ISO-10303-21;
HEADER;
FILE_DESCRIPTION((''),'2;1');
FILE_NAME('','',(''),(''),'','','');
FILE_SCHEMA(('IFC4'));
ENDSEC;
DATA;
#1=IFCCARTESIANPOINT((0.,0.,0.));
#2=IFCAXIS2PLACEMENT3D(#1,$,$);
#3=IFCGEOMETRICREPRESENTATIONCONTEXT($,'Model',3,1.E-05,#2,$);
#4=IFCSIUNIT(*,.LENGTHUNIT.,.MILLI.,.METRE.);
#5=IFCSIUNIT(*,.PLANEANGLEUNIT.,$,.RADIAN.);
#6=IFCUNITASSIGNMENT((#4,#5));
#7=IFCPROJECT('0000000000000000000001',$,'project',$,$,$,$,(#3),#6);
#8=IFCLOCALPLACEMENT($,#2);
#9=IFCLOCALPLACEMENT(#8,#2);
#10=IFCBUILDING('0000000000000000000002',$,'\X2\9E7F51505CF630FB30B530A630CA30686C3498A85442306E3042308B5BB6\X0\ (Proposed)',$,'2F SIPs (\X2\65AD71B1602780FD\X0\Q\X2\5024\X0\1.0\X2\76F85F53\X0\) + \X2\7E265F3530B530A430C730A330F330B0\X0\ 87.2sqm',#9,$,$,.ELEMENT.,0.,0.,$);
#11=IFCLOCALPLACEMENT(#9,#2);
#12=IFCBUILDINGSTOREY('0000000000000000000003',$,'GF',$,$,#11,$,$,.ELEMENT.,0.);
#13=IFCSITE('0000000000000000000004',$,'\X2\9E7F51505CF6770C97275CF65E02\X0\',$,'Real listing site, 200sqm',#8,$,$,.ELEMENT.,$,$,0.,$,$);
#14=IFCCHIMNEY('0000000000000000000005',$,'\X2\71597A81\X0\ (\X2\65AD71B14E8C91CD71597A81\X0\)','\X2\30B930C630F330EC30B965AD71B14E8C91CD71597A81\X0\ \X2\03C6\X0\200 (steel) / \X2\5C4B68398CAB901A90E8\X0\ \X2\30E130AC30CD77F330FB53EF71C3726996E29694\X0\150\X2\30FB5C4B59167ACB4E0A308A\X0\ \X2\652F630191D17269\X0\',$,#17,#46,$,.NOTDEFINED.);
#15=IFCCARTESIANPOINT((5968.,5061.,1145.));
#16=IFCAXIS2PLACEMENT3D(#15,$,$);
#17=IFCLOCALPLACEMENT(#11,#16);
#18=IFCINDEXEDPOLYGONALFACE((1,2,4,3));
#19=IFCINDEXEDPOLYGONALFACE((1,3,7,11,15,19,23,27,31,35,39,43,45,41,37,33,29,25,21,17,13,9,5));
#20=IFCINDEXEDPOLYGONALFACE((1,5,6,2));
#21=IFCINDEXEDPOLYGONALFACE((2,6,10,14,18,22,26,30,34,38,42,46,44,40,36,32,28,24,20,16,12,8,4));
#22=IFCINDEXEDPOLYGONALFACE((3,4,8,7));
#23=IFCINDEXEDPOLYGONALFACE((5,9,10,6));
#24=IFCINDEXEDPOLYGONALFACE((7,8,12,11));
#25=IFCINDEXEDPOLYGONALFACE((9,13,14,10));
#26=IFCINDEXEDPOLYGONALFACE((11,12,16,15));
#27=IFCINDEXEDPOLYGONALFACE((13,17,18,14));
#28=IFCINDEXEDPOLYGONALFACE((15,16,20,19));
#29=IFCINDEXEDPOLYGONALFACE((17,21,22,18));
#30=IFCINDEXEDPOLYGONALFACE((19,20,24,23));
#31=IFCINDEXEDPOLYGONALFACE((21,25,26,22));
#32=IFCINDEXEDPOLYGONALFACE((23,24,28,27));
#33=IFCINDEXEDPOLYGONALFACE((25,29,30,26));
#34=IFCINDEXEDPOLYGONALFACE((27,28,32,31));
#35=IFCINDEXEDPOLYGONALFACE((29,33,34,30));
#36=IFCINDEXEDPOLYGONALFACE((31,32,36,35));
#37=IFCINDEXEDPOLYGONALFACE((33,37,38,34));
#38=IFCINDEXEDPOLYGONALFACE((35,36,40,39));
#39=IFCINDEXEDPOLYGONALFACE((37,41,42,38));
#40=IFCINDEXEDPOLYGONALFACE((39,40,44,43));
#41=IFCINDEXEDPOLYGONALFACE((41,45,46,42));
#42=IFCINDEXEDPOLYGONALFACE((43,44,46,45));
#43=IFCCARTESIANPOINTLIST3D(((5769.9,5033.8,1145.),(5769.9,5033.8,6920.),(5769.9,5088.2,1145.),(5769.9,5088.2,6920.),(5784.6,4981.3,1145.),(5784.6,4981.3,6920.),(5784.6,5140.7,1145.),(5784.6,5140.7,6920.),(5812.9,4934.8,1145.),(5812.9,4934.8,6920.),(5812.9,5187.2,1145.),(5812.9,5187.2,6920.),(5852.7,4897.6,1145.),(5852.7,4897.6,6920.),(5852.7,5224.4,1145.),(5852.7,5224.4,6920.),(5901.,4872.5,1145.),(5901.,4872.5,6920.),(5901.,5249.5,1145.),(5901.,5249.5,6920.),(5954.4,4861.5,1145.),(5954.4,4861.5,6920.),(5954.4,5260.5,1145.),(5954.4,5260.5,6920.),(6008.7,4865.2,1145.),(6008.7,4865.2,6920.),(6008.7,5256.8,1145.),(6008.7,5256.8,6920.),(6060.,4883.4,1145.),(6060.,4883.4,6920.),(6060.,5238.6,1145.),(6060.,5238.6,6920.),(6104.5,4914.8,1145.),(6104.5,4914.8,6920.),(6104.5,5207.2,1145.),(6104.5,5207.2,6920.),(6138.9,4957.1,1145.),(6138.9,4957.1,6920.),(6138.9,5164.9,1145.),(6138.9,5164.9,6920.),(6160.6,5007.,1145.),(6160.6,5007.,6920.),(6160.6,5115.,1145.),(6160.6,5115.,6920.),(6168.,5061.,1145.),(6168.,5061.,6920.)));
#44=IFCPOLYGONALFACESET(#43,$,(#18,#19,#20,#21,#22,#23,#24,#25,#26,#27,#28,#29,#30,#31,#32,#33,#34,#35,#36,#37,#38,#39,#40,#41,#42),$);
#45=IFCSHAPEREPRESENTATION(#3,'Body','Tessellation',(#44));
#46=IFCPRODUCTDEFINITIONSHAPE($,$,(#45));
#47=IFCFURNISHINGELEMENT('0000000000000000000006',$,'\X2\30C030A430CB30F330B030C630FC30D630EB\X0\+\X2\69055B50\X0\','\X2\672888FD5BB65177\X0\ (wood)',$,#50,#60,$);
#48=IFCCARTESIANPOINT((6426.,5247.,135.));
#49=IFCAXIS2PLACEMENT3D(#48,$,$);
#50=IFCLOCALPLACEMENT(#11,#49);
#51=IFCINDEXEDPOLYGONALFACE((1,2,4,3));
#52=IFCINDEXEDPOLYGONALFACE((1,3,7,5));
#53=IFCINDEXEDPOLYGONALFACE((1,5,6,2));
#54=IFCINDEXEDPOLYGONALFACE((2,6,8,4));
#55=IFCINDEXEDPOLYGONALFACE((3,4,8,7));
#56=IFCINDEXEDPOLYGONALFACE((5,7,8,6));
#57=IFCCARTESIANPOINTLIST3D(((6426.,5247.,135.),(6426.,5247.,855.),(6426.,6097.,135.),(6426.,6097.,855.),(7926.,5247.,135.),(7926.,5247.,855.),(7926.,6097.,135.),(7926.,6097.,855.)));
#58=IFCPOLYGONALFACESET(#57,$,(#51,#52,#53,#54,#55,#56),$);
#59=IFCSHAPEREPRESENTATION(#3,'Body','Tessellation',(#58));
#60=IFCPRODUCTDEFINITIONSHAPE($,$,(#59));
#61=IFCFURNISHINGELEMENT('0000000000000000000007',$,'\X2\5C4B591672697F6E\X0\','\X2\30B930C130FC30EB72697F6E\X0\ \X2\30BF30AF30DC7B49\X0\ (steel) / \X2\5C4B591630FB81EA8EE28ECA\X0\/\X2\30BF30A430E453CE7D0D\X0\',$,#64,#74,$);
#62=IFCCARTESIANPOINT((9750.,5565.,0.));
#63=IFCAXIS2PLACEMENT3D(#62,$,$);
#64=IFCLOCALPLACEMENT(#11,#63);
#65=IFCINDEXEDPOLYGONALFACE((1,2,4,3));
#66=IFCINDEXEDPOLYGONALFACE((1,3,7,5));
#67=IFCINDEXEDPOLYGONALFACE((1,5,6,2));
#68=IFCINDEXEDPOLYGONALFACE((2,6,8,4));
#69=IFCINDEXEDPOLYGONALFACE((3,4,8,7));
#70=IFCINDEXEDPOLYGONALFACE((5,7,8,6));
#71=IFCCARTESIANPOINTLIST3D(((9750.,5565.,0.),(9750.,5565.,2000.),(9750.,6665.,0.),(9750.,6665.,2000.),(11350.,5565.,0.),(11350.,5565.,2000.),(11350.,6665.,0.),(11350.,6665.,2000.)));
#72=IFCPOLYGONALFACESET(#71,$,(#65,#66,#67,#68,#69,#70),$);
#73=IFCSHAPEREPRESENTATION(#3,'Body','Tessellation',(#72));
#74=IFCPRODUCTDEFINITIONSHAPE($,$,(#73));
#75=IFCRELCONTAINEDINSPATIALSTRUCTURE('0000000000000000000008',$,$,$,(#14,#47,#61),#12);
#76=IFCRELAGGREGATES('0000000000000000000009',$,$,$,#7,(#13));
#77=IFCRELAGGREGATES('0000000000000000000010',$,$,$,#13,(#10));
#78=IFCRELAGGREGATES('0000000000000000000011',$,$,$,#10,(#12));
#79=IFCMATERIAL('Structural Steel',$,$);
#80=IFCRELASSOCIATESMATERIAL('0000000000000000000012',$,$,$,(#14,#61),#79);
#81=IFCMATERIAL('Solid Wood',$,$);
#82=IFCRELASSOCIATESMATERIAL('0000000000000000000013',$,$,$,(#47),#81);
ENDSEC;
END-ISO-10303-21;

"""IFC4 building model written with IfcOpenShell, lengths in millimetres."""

from ifc_helpers import new_model, si_unit, frame, frame_2d, origin, origin_2d, place, context, project, spatial, rectangle, circle, extrude, material, element, save


model = new_model("IFC4")

# Units and contexts
model_context = context("Model", 3, precision=1e-05, world=origin())
ifc_project = project(units=[si_unit("LENGTHUNIT", "METRE", prefix="MILLI"), si_unit("PLANEANGLEUNIT", "RADIAN")], contexts=[model_context])

# Site, building, storey
site_placement = place(None, origin())
site = spatial("IfcSite", under=ifc_project, at=site_placement, Name="鹿児島県霧島市", ObjectType="Real listing site, 200sqm", CompositionType="ELEMENT", RefElevation=0.0)
building_placement = place(site_placement, origin())
building = spatial("IfcBuilding", under=site, at=building_placement, Name="鹿児島・サウナと水風呂のある家 (Proposed)", ObjectType="2F SIPs (断熱性能Q値1.0相当) + 縦張サイディング 87.2sqm", CompositionType="ELEMENT", ElevationOfRefHeight=0.0, ElevationOfTerrain=0.0)
storey_placement = place(building_placement, origin())
storey = spatial("IfcBuildingStorey", under=building, at=storey_placement, Name="GF", CompositionType="ELEMENT", Elevation=0.0)

# Shared definitions
ifc_material_1 = material(Name="Solid Wood")

# Shared definitions
ifc_material_2 = material(Name="Structural Steel")

# Chimney
chimney_placement = place(storey_placement, frame((5968.0, 5061.0, 1145.0)))
element("IfcChimney", 1, at=chimney_placement, inside=storey, material=ifc_material_2, Name="煙突 (断熱二重煙突)", Description="ステンレス断熱二重煙突 φ200 (steel) / 屋根貫通部 メガネ石・可燃物離隔150・屋外立上り 支持金物", PredefinedType="NOTDEFINED", context=model_context, shape_type="SweptSolid", body=[
    extrude(circle(Radius=200.0, at=origin_2d()), frame((5968.0, 5061.0, 1145.0)), (0.0, 0.0, 1.0), 5775.0),
])

# Furnishing elements
furnishing_1_placement = place(storey_placement, frame((6426.0, 5247.0, 135.0)))
element("IfcFurnishingElement", 2, at=furnishing_1_placement, inside=storey, material=ifc_material_1, Name="ダイニングテーブル+椅子", Description="木製家具 (wood)", context=model_context, shape_type="SweptSolid", body=[
    extrude(rectangle(XDim=1500.0, YDim=850.0, at=frame_2d((750.0, 425.0))), frame((6426.0, 5247.0, 135.0)), (0.0, 0.0, 1.0), 720.0),
])
furnishing_2_placement = place(storey_placement, frame((9750.0, 5565.0, 0.0)))
element("IfcFurnishingElement", 3, at=furnishing_2_placement, inside=storey, material=ifc_material_2, Name="屋外物置", Description="スチール物置 タクボ等 (steel) / 屋外・自転車/タイヤ収納", context=model_context, shape_type="SweptSolid", body=[
    extrude(rectangle(XDim=1600.0, YDim=1100.0, at=frame_2d((800.0, 550.0))), frame((9750.0, 5565.0, 0.0)), (0.0, 0.0, 1.0), 2000.0),
])

save(model, "model.ifc")
